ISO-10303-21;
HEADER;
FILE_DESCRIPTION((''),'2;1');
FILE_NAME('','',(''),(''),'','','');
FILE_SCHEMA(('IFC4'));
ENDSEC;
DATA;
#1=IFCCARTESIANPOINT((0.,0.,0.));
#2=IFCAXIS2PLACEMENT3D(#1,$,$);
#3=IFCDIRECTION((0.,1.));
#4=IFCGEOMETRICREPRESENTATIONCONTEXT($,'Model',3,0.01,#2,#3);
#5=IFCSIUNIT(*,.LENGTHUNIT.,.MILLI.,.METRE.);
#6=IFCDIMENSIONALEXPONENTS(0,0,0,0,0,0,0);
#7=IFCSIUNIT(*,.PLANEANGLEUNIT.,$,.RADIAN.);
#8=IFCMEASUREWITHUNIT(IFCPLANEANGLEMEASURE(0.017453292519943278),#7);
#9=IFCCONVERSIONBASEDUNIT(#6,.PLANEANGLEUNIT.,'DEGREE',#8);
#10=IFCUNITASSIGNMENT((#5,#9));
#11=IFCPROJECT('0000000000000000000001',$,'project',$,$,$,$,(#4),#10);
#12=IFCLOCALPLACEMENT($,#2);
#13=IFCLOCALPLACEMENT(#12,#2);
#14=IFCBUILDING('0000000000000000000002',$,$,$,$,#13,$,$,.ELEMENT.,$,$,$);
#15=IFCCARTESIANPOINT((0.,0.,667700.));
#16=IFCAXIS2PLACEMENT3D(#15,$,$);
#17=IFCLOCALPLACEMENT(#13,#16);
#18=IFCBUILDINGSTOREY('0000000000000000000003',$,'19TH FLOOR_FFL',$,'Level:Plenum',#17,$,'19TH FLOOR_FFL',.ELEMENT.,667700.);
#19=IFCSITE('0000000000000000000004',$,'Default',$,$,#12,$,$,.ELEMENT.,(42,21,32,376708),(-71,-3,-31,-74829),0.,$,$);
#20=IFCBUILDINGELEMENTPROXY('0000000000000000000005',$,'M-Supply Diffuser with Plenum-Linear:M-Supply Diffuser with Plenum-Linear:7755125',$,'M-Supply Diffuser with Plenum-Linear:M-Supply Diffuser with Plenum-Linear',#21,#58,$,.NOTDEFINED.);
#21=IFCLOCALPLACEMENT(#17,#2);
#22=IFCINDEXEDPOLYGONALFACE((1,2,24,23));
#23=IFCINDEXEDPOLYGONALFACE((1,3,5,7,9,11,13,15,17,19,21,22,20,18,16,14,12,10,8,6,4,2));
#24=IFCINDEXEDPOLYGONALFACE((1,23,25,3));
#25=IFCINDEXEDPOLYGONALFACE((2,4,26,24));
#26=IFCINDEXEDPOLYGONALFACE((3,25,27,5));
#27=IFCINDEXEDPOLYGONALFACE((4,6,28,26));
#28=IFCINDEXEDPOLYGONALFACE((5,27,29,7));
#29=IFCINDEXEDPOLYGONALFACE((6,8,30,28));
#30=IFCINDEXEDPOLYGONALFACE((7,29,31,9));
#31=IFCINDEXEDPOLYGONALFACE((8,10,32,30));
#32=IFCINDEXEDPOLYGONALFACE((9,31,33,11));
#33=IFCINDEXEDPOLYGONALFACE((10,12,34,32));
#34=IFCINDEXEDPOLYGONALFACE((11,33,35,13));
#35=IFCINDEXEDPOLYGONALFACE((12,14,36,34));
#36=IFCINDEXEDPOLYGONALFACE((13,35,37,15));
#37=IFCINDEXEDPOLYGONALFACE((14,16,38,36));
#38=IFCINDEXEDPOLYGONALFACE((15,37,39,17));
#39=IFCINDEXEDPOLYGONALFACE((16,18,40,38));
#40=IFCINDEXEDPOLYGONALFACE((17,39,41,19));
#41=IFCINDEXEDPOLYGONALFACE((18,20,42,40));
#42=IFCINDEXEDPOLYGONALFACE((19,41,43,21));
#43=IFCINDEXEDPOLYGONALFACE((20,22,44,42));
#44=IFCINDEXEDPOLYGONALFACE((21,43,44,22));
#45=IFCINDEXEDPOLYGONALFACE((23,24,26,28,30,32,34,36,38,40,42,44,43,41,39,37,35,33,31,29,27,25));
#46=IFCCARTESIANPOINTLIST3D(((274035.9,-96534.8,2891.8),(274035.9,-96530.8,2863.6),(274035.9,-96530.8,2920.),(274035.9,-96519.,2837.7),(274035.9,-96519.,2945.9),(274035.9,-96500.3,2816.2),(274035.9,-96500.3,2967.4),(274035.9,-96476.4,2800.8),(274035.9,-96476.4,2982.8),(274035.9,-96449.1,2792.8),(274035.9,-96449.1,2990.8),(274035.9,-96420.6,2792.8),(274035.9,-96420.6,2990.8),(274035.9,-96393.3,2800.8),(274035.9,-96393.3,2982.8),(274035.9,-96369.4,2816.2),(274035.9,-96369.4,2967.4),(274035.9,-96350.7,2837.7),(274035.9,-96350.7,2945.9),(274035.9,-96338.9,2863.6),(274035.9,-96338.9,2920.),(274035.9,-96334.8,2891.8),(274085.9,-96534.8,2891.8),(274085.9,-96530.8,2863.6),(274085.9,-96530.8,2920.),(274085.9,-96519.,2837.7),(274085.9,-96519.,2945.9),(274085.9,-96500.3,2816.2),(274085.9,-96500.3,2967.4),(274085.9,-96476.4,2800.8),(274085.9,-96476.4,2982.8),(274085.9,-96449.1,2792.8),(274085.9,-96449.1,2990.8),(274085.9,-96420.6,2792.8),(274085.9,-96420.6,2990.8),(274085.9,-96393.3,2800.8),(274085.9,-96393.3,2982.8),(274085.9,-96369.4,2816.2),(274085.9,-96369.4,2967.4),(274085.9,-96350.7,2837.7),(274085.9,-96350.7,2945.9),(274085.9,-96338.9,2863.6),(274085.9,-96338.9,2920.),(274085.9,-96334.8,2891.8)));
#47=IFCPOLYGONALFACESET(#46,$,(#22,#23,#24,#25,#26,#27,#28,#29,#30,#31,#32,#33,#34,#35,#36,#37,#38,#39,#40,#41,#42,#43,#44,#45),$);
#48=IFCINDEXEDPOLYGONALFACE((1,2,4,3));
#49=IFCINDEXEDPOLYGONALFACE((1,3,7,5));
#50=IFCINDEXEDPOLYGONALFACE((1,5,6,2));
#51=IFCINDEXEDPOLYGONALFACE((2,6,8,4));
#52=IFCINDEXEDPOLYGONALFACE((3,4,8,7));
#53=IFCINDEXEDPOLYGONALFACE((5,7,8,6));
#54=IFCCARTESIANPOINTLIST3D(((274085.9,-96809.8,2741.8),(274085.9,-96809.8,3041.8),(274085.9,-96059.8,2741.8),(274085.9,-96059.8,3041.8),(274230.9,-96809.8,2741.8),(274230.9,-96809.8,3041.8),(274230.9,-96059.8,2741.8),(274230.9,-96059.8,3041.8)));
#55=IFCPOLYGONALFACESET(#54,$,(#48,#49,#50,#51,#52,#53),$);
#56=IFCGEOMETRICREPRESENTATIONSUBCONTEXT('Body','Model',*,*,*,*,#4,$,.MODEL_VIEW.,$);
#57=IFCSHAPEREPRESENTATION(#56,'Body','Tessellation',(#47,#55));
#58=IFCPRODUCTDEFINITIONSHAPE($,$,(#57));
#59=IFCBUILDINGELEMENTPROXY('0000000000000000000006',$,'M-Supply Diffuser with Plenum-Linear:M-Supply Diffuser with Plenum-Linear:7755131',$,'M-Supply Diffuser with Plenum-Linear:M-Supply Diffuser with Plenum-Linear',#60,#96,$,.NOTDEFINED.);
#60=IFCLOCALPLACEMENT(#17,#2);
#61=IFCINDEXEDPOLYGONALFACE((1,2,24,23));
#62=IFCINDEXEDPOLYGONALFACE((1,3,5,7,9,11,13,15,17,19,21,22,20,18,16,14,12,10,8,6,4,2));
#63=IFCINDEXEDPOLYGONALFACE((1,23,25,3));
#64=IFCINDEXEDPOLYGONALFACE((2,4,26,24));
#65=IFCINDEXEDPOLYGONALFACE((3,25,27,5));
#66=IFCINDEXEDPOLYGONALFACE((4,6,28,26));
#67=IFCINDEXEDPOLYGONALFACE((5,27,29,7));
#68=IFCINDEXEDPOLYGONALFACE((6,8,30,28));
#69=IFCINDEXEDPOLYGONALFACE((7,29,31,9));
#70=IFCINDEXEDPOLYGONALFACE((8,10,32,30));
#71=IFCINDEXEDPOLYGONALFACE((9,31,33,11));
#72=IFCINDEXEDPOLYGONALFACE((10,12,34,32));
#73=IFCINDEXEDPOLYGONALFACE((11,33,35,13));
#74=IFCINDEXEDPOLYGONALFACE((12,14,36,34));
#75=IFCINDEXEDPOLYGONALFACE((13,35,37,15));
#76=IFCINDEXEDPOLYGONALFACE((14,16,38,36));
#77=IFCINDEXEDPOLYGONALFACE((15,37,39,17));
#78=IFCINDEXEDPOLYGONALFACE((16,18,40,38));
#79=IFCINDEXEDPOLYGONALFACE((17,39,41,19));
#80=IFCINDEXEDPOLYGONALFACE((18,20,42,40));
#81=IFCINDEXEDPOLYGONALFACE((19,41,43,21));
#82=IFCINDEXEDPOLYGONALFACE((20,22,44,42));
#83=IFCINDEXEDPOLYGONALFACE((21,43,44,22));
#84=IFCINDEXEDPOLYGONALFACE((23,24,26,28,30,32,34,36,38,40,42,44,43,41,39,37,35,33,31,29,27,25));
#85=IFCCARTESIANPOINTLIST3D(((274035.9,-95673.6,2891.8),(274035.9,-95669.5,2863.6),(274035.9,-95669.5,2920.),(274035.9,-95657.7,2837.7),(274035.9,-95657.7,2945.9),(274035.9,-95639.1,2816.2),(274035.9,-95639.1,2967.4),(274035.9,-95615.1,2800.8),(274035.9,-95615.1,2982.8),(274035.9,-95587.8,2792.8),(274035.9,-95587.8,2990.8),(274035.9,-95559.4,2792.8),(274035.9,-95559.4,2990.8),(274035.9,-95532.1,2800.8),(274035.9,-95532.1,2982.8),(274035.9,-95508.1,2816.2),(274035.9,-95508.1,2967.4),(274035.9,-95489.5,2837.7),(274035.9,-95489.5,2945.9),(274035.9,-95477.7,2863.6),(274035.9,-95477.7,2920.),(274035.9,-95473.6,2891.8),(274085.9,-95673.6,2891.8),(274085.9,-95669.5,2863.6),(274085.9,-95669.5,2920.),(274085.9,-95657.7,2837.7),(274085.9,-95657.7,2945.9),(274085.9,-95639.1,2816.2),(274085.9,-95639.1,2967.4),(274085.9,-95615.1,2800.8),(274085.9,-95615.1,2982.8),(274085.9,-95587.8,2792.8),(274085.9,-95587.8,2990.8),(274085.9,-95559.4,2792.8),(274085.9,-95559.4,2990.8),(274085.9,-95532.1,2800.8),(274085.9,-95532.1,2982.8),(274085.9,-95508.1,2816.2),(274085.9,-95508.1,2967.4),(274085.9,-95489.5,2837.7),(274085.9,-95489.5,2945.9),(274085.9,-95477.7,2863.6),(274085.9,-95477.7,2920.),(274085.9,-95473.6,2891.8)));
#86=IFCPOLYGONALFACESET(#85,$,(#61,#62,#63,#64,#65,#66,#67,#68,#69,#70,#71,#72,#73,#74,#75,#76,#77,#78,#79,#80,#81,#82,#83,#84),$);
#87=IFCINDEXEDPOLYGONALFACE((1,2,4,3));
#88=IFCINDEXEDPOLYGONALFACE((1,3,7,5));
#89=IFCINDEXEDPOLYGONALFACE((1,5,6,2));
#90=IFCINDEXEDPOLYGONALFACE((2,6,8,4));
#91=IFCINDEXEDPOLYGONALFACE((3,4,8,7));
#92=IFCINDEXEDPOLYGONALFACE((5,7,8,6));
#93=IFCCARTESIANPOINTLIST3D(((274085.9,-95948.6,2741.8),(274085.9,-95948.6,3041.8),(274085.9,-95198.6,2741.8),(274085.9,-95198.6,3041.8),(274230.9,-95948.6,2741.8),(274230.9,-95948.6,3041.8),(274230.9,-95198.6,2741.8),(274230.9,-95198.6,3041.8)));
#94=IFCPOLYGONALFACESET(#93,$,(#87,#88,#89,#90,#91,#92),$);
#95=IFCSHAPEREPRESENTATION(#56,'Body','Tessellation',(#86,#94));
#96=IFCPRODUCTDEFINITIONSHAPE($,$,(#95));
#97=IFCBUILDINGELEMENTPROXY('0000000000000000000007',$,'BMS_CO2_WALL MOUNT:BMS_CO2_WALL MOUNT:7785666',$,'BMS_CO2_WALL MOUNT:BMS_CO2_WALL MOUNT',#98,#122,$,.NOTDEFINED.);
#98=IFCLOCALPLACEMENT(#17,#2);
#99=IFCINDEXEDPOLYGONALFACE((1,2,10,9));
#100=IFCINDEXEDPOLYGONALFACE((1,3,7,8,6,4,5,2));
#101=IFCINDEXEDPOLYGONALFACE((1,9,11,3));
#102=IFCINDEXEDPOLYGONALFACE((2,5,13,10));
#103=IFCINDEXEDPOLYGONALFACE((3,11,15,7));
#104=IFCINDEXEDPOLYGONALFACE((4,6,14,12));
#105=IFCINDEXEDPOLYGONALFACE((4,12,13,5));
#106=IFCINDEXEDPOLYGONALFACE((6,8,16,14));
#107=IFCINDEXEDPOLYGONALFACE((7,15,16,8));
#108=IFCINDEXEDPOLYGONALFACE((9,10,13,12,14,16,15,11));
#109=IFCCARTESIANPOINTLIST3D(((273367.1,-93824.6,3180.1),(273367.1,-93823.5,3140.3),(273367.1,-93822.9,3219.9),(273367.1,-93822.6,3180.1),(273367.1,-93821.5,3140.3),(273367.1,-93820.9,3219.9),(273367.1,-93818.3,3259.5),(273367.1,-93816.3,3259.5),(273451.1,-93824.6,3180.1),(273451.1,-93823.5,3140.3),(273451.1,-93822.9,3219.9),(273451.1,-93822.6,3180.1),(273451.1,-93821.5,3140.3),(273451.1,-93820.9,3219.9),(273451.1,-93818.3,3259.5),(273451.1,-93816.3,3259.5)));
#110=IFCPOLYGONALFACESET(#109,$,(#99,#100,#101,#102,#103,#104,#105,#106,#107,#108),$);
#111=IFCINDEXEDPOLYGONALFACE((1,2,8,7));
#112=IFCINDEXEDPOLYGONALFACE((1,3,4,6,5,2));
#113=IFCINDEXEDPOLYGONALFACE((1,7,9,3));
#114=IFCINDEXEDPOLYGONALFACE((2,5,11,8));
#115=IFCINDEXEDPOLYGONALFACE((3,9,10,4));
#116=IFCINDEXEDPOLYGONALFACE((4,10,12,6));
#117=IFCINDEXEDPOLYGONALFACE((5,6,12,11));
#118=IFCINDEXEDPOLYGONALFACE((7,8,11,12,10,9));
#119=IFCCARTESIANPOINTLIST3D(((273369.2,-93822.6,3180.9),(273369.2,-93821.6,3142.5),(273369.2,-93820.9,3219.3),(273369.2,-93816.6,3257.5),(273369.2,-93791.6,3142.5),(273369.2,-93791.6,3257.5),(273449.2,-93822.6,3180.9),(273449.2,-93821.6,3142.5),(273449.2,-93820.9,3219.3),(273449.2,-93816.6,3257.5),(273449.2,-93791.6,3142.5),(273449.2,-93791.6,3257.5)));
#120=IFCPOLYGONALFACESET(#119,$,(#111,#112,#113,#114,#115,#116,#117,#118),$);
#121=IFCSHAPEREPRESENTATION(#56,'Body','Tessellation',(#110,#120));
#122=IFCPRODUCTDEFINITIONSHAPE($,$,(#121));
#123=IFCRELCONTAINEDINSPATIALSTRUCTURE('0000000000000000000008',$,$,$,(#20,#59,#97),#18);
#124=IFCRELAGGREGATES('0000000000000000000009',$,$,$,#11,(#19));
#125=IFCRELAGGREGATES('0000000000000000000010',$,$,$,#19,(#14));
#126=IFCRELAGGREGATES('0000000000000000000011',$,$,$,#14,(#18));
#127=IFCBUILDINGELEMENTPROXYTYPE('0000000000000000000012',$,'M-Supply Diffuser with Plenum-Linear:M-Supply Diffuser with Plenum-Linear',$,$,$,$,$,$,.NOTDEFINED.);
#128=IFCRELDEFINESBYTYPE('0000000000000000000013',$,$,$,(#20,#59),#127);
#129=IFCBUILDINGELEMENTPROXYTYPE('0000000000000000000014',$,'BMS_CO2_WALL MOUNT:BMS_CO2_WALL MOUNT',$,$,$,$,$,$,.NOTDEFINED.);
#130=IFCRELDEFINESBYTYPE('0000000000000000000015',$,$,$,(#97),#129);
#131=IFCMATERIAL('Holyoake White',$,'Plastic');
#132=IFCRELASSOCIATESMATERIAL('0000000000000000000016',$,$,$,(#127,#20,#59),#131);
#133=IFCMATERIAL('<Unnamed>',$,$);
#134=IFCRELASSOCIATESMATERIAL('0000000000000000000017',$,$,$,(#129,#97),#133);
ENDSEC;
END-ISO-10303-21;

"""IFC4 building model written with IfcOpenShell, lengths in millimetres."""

from ifc_helpers import new_model, entity, si_unit, converted_unit, direction, frame, origin, place, context, subcontext, project, spatial, line, arc, indexed_curve, outline, extrude, source, transform, mapped, material, type_object, type_shapes, element, save


model = new_model("IFC4")

# Units and contexts
model_context = context("Model", 3, precision=0.01, world=origin(), true_north=direction((0.0, 1.0)))
body_context = subcontext(model_context, "Body", "Model", "MODEL_VIEW")
ifc_project = project(units=[si_unit("LENGTHUNIT", "METRE", prefix="MILLI"), converted_unit("PLANEANGLEUNIT", "DEGREE", entity("IfcPlaneAngleMeasure", 0.017453292519943278), si_unit("PLANEANGLEUNIT", "RADIAN"), dimensions=[0, 0, 0, 0, 0, 0, 0])], contexts=[model_context])

# Site, building, storey
site_placement = place(None, origin())
site = spatial("IfcSite", under=ifc_project, at=site_placement, Name="Default", CompositionType="ELEMENT", RefLatitude=(42, 21, 32, 376708), RefLongitude=(-71, -3, -31, -74829), RefElevation=0.0)
building_placement = place(site_placement, origin())
building = spatial("IfcBuilding", under=site, at=building_placement, CompositionType="ELEMENT")
storey_placement = place(building_placement, frame((0.0, 0.0, 667700.0)))
storey = spatial("IfcBuildingStorey", under=building, at=storey_placement, Name="19TH FLOOR_FFL", ObjectType="Level:Plenum", LongName="19TH FLOOR_FFL", CompositionType="ELEMENT", Elevation=667700.0)

# Shared definitions
ifc_material_1 = material(Name="<Unnamed>")

# Building element proxies
ifc_material_2 = material(Name="Holyoake White", Category="Plastic")
building_element_proxy_type_1 = type_object("IfcBuildingElementProxyType", Name="M-Supply Diffuser with Plenum-Linear:M-Supply Diffuser with Plenum-Linear", PredefinedType="NOTDEFINED", material=ifc_material_2)
shared_shape_1 = source(origin(), body_context, "Body", "SweptSolid", [
    extrude(outline(indexed_curve([(-100.0, 0.0), (0.0, -100.0), (100.0, 0.0), (0.0, 100.0)], segments=[arc(1, 2, 3), arc(3, 4, 1)], self_intersect=False)), frame((0.0, 72.5, 195.0), z_axis=(0.0, 1.0, 0.0), x_axis=(1.0, 0.0, 0.0)), (0.0, 0.0, 1.0), 50.0),
    extrude(outline(indexed_curve([(-72.5, -375.0), (72.5, -375.0), (72.5, 375.0), (-72.5, 375.0), (-72.5, -375.0)], self_intersect=False)), frame((0.0, 0.0, 45.0), z_axis=(0.0, 0.0, 1.0), x_axis=(0.0, 1.0, 0.0)), (0.0, 0.0, 1.0), 300.0),
])
type_shapes(building_element_proxy_type_1, [shared_shape_1])
for number, where, z_axis, x_axis, name in (
    (1, (274158.4, -96434.8, 2696.8), (0.0, 0.0, 1.0), (0.0, 1.0, 0.0), "M-Supply Diffuser with Plenum-Linear:M-Supply Diffuser with Plenum-Linear:7755125"),
    (2, (274158.4, -95573.6, 2696.8), (0.0, 0.0, 1.0), (0.0, 1.0, 0.0), "M-Supply Diffuser with Plenum-Linear:M-Supply Diffuser with Plenum-Linear:7755131"),
):
    element("IfcBuildingElementProxy", number, at=place(storey_placement, frame(where, z_axis=z_axis, x_axis=x_axis)), inside=storey, type_object=building_element_proxy_type_1, material=ifc_material_2, Name=name, ObjectType="M-Supply Diffuser with Plenum-Linear:M-Supply Diffuser with Plenum-Linear", PredefinedType="NOTDEFINED", context=body_context, shape_type="MappedRepresentation", body=[
        mapped(shared_shape_1, transform((0.0, 0.0, 0.0), scale=1.0)),
    ])
building_element_proxy_type_2 = type_object("IfcBuildingElementProxyType", Name="BMS_CO2_WALL MOUNT:BMS_CO2_WALL MOUNT", PredefinedType="NOTDEFINED", material=ifc_material_1)
shared_shape_2 = source(origin(), body_context, "Body", "SweptSolid", [
    extrude(outline(indexed_curve([(-59.6, -1.6), (-59.6, -3.6), (0.1, -4.2), (59.6, 1.6), (59.6, 3.6), (0.1, -2.2)], segments=[line(1, 2), arc(2, 3, 4), line(4, 5), arc(5, 6, 1)], self_intersect=False)), frame((-42.0, -0.1, 28.3), z_axis=(-1.0, 0.0, 0.0), x_axis=(0.0, 1.0, 0.0)), (0.0, 0.0, -1.0), 84.0),
    extrude(outline(indexed_curve([(-13.7, -57.5), (11.3, -57.5), (16.7, -0.1), (16.2, 57.5), (-13.7, 57.5)], segments=[line(1, 2), arc(2, 3, 4), line(4, 5, 1)], self_intersect=False)), frame((-40.0, 0.0, 13.7), z_axis=(1.0, 0.0, 0.0), x_axis=(0.0, 0.0, 1.0)), (0.0, 0.0, 1.0), 80.0),
])
type_shapes(building_element_proxy_type_2, [shared_shape_2])
proxy_1_placement = place(storey_placement, frame((273409.2, -93791.6, 3200.0), z_axis=(0.0, -1.0, 0.0), x_axis=(1.0, 0.0, 0.0)))
element("IfcBuildingElementProxy", 3, at=proxy_1_placement, inside=storey, type_object=building_element_proxy_type_2, material=ifc_material_1, Name="BMS_CO2_WALL MOUNT:BMS_CO2_WALL MOUNT:7785666", ObjectType="BMS_CO2_WALL MOUNT:BMS_CO2_WALL MOUNT", PredefinedType="NOTDEFINED", context=body_context, shape_type="MappedRepresentation", body=[
    mapped(shared_shape_2, transform((0.0, 0.0, 0.0), scale=1.0)),
])

save(model, "model.ifc")
